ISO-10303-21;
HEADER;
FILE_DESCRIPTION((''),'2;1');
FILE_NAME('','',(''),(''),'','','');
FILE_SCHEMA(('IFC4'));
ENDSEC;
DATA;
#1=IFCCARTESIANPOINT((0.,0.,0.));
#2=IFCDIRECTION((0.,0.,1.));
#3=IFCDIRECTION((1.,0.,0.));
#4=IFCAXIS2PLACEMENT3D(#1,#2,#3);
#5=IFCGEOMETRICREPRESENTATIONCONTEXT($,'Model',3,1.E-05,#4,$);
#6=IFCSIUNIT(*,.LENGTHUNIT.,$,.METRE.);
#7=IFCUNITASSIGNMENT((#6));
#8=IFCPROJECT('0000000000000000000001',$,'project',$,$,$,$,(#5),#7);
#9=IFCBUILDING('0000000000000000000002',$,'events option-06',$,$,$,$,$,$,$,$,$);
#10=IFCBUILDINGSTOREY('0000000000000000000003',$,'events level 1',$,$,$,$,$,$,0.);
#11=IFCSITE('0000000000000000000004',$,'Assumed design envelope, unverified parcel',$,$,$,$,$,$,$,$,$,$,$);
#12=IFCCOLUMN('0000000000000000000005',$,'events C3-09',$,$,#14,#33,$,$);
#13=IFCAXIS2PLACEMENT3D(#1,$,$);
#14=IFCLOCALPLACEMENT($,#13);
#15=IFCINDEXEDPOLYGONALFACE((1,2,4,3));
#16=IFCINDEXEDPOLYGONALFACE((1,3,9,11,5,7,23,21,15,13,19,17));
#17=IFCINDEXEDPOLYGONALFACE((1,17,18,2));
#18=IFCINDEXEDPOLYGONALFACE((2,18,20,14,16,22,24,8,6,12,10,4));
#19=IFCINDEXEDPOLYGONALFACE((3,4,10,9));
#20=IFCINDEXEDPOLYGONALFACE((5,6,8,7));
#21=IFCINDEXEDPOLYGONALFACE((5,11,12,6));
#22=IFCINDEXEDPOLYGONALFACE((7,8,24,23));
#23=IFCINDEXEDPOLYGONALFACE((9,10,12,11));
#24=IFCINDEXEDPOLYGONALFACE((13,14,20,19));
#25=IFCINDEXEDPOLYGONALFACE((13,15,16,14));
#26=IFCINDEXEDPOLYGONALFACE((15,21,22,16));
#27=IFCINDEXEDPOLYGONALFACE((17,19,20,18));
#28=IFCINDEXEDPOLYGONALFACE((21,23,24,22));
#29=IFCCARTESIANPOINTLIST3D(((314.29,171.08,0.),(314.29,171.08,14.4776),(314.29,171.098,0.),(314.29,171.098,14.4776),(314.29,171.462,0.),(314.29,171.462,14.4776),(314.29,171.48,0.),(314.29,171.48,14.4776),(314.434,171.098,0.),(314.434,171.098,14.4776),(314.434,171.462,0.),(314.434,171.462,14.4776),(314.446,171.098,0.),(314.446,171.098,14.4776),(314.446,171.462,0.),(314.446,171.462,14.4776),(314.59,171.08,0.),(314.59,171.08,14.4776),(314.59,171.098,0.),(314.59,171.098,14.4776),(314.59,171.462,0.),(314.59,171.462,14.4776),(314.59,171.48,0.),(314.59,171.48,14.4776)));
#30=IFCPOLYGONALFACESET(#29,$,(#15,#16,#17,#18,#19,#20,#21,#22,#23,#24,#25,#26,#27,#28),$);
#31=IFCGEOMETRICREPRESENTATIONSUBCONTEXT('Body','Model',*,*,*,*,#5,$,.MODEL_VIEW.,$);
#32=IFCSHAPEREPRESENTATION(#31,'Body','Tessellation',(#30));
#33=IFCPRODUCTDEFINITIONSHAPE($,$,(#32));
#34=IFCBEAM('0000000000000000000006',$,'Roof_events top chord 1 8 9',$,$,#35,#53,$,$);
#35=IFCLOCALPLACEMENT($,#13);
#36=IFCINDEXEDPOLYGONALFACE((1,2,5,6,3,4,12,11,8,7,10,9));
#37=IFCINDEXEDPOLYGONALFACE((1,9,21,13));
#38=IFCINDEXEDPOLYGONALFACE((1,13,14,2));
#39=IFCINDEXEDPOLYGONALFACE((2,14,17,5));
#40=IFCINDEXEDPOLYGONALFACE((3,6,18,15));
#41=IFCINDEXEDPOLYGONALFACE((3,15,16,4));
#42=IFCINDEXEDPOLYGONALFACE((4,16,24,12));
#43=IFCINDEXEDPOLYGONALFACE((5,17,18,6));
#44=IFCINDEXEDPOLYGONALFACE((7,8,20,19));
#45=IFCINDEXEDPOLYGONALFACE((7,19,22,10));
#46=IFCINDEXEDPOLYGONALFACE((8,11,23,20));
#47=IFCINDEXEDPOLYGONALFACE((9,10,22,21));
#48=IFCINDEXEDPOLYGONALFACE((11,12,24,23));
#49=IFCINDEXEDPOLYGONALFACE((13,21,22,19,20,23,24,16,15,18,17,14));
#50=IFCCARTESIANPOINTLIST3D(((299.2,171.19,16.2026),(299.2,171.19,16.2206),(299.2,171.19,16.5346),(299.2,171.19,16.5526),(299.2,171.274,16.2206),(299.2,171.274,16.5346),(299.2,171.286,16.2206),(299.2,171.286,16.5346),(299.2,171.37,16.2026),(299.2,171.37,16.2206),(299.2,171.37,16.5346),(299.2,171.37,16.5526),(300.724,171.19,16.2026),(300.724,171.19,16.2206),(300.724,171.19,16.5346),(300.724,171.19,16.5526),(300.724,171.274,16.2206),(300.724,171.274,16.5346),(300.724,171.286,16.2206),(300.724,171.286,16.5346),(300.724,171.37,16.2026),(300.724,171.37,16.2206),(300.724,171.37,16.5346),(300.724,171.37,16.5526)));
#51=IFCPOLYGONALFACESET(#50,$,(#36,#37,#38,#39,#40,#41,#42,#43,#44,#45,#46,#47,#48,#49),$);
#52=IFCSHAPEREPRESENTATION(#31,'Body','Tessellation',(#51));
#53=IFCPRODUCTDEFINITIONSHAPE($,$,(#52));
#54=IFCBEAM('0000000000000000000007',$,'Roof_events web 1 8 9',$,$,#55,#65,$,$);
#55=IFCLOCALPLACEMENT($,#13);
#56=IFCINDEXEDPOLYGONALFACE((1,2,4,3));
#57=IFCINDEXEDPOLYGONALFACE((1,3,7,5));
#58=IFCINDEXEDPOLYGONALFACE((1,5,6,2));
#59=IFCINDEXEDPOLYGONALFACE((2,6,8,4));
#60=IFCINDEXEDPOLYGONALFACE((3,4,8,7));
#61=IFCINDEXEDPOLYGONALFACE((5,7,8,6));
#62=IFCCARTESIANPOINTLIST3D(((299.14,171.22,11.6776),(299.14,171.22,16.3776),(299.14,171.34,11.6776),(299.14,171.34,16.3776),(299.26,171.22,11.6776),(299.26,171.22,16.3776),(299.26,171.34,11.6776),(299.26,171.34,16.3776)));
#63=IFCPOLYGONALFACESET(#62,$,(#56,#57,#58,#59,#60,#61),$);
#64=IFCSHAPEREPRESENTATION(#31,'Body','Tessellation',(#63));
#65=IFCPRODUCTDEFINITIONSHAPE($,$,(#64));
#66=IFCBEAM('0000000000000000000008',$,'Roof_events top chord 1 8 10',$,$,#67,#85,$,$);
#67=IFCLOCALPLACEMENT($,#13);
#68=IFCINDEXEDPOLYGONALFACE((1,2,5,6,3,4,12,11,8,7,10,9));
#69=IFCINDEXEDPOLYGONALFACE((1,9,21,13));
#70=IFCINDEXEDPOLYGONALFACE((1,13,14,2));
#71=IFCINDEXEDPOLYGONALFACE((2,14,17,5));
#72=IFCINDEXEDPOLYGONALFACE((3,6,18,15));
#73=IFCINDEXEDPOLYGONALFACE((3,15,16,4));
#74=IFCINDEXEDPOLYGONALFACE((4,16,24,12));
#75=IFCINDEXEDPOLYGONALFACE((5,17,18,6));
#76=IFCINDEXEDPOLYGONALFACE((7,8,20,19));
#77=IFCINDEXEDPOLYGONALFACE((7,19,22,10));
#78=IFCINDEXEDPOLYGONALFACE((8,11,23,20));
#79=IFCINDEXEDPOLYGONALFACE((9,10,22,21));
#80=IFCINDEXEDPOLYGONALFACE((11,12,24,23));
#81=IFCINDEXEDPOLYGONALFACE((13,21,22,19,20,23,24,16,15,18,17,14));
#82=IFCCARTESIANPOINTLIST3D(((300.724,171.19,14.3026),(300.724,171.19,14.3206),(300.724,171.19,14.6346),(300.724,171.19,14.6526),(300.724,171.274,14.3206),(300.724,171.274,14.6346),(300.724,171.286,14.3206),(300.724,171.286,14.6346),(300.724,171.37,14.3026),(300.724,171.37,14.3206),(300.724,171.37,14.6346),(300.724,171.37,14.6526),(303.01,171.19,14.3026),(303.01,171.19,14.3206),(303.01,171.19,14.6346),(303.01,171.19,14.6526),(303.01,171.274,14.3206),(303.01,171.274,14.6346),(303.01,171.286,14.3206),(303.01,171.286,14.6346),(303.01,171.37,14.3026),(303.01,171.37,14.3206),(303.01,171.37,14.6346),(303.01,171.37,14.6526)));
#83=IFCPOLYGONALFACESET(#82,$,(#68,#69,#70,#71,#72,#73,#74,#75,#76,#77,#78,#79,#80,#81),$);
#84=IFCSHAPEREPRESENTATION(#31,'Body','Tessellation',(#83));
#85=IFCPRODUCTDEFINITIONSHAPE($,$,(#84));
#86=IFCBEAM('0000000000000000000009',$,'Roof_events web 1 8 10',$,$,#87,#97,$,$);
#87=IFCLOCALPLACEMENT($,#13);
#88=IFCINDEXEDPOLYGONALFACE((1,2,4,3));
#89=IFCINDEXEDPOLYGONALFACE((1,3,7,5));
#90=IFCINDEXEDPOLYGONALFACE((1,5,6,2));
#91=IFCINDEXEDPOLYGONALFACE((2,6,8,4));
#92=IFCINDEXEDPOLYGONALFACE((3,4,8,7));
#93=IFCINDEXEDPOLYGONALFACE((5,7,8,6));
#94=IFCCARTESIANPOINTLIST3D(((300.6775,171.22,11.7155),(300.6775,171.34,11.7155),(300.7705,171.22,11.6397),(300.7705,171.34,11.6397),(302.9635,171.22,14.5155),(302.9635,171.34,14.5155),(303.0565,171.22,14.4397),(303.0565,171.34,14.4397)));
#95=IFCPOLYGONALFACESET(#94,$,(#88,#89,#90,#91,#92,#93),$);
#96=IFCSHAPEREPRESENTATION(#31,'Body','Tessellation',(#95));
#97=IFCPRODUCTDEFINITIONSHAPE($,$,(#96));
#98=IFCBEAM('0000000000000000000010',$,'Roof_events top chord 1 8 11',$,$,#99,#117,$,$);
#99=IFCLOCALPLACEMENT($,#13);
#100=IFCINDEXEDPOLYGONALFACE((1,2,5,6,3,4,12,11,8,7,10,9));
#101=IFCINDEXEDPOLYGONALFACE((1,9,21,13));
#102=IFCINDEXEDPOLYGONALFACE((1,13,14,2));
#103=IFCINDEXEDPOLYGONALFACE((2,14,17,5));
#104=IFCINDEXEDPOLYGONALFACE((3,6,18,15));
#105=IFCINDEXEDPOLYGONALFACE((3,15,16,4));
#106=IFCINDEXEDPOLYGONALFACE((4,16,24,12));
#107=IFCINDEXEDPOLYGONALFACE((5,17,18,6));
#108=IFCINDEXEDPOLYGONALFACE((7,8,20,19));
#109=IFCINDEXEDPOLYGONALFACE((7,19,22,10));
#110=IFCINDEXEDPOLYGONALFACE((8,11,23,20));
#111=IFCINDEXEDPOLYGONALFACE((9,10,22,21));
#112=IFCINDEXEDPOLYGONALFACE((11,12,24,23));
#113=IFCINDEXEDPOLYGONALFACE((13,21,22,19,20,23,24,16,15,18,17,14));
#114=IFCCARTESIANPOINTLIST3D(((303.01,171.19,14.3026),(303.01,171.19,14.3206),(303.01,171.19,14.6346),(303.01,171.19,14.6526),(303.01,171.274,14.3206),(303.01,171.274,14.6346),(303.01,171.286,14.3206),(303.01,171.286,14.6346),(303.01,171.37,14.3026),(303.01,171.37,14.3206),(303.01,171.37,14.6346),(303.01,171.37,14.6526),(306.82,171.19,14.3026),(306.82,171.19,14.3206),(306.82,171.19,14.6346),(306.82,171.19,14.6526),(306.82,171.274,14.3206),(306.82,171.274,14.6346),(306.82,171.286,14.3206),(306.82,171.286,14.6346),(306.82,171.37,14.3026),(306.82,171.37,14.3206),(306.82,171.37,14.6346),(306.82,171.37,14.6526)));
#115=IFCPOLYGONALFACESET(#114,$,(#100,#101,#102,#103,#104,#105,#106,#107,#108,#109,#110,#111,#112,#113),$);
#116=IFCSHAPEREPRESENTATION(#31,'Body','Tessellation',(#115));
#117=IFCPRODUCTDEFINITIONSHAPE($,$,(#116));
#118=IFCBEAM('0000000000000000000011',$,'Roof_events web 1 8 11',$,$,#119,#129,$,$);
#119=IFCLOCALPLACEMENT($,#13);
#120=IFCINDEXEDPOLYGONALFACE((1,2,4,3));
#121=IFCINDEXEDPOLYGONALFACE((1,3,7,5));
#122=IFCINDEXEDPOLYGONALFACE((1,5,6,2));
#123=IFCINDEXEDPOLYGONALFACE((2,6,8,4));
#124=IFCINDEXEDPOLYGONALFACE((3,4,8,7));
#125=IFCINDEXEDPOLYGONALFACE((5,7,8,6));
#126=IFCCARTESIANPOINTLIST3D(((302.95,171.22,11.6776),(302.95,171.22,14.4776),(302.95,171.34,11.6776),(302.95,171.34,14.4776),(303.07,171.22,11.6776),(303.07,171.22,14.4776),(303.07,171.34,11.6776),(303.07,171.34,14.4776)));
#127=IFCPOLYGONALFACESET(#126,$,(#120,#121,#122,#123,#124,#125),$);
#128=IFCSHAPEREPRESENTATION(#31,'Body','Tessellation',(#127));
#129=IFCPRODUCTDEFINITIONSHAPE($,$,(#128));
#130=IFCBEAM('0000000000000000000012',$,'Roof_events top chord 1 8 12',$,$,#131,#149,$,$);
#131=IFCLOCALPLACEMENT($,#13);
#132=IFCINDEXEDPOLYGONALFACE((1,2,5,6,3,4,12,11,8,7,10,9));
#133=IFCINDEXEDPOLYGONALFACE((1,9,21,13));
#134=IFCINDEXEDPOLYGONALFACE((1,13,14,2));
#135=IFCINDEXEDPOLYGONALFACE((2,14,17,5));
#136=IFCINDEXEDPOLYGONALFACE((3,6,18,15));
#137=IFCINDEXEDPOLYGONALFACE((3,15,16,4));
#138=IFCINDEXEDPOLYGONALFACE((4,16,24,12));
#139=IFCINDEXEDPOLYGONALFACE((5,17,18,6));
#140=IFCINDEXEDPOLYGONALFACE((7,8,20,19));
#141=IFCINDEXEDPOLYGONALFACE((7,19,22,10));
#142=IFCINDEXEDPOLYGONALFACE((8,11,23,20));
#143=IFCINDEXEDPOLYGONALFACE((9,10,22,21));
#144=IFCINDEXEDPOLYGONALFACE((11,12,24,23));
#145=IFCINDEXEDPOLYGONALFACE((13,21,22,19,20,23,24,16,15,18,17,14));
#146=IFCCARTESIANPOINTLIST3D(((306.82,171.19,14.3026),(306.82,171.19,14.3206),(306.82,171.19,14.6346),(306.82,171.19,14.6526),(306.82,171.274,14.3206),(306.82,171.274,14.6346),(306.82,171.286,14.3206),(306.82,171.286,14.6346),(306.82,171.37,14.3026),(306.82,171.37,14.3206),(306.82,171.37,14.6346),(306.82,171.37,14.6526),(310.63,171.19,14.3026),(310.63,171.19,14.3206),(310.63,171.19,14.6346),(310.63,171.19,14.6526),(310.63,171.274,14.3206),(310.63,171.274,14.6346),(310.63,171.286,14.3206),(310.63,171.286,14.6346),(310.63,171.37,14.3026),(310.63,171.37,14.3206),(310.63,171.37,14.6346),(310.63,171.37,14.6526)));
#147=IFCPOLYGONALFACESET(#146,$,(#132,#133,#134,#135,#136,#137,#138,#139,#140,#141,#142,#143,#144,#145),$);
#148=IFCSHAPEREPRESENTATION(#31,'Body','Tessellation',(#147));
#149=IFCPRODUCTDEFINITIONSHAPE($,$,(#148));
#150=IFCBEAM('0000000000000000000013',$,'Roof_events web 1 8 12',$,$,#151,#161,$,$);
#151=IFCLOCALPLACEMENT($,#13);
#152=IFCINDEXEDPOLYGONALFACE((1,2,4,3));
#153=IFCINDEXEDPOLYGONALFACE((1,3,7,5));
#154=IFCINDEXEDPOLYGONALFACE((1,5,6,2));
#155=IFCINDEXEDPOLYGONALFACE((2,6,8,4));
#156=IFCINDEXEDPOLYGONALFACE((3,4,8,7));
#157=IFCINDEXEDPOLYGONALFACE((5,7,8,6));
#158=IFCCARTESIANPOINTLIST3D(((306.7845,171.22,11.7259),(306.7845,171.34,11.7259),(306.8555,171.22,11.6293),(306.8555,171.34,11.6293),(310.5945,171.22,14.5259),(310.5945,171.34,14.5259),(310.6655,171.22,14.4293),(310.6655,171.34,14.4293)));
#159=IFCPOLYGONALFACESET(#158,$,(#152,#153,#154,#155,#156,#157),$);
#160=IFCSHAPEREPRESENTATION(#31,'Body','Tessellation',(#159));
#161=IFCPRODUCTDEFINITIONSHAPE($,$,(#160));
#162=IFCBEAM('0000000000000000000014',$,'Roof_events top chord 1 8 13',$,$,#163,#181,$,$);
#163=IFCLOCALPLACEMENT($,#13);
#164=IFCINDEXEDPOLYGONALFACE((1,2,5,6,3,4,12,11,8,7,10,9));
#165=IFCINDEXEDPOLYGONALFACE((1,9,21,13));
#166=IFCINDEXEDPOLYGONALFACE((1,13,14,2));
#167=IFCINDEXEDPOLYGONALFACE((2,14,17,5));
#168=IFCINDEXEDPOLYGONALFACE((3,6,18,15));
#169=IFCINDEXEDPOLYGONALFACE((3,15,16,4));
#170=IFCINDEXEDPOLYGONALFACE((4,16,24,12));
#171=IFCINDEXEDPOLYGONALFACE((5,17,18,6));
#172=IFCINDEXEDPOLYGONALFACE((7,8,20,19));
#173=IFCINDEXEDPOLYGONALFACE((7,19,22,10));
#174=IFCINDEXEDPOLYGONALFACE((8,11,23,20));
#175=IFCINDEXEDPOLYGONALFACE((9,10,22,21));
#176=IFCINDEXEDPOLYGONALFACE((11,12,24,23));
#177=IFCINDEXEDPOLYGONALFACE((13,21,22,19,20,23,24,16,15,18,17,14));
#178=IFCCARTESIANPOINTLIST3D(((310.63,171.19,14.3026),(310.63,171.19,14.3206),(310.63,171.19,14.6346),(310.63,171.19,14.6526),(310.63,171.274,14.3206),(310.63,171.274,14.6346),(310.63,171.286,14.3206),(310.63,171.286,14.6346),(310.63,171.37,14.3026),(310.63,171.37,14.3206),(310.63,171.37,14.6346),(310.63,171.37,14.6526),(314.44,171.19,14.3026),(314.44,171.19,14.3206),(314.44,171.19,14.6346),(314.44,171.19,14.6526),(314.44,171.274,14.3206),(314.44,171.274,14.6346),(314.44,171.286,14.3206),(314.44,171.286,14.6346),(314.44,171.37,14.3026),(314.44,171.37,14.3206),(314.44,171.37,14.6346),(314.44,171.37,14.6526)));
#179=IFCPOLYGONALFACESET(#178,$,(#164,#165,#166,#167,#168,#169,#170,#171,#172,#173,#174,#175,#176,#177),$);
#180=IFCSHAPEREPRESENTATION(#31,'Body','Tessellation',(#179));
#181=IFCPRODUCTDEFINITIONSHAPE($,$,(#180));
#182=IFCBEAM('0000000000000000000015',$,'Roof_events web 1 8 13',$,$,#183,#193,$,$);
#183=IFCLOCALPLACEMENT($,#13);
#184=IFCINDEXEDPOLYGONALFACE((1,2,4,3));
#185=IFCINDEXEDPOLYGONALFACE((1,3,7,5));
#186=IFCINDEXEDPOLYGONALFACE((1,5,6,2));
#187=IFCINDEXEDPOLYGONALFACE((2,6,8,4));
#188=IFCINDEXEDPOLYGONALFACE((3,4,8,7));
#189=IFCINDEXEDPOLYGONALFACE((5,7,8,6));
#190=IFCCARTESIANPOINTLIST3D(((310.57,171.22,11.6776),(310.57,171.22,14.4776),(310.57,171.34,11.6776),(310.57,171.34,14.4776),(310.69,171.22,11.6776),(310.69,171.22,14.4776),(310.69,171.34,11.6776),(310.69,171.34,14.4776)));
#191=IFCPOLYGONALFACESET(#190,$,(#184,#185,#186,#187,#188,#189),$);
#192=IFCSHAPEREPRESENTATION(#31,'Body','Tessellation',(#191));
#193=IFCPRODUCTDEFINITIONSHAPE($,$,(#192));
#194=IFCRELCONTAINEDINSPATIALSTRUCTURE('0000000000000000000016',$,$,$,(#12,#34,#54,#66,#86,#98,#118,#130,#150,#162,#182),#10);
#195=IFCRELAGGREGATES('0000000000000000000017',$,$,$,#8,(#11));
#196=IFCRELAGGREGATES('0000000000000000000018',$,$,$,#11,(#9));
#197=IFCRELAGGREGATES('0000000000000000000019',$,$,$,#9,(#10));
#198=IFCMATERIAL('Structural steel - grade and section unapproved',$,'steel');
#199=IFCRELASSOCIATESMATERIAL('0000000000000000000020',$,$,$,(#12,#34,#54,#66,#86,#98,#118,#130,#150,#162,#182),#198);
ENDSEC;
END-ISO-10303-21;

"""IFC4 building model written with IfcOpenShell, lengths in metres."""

from ifc_helpers import new_model, si_unit, frame, origin_with_axes, place, context, subcontext, project, spatial, rectangle, i_section, extrude, material, element, save


model = new_model("IFC4")

# Units and contexts
model_context = context("Model", 3, precision=1e-05, world=origin_with_axes())
body_context = subcontext(model_context, "Body", "Model", "MODEL_VIEW")
ifc_project = project(units=[si_unit("LENGTHUNIT", "METRE")], contexts=[model_context])

# Site, building, storey
site = spatial("IfcSite", under=ifc_project, Name="Assumed design envelope, unverified parcel")
building = spatial("IfcBuilding", under=site, Name="events option-06")
storey = spatial("IfcBuildingStorey", under=building, Name="events level 1", Elevation=0.0)

# Column
ifc_material_1 = material(Name="Structural steel - grade and section unapproved", Category="steel")
column_placement = place(None, frame((314.44, 171.28, 0.0), z_axis=(0.0, 0.0, 1.0), x_axis=(-1.0, 0.0, 0.0)))
element("IfcColumn", 1, at=column_placement, inside=storey, material=ifc_material_1, Name="events C3-09", context=body_context, shape_type="SweptSolid", body=[
    extrude(i_section(OverallWidth=0.3, OverallDepth=0.4, WebThickness=0.012, FlangeThickness=0.018, FilletRadius=0.0), origin_with_axes(), (0.0, 0.0, 1.0), 14.4776),
])

# Beams
beam_1_placement = place(None, frame((299.2, 171.28, 16.3776), z_axis=(1.0, 0.0, 0.0), x_axis=(0.0, 1.0, 0.0)))
element("IfcBeam", 2, at=beam_1_placement, inside=storey, material=ifc_material_1, Name="Roof_events top chord 1 8 9", context=body_context, shape_type="SweptSolid", body=[
    extrude(i_section(OverallWidth=0.18, OverallDepth=0.35, WebThickness=0.012, FlangeThickness=0.018, FilletRadius=0.0), origin_with_axes(), (0.0, 0.0, 1.0), 1.524),
])
beam_2_placement = place(None, frame((299.2, 171.28, 11.6776), z_axis=(0.0, 0.0, 1.0), x_axis=(-1.0, 0.0, 0.0)))
element("IfcBeam", 3, at=beam_2_placement, inside=storey, material=ifc_material_1, Name="Roof_events web 1 8 9", context=body_context, shape_type="SweptSolid", body=[
    extrude(rectangle(XDim=0.12, YDim=0.12), origin_with_axes(), (0.0, 0.0, 1.0), 4.7),
])
beam_3_placement = place(None, frame((300.724, 171.28, 14.4776), z_axis=(1.0, 0.0, 0.0), x_axis=(0.0, 1.0, 0.0)))
element("IfcBeam", 4, at=beam_3_placement, inside=storey, material=ifc_material_1, Name="Roof_events top chord 1 8 10", context=body_context, shape_type="SweptSolid", body=[
    extrude(i_section(OverallWidth=0.18, OverallDepth=0.35, WebThickness=0.012, FlangeThickness=0.018, FilletRadius=0.0), origin_with_axes(), (0.0, 0.0, 1.0), 2.286),
])
beam_4_placement = place(None, frame((300.724, 171.28, 11.6776), z_axis=(0.632426, 0.0, 0.774621), x_axis=(0.0, 1.0, 0.0)))
element("IfcBeam", 5, at=beam_4_placement, inside=storey, material=ifc_material_1, Name="Roof_events web 1 8 10", context=body_context, shape_type="SweptSolid", body=[
    extrude(rectangle(XDim=0.12, YDim=0.12), origin_with_axes(), (0.0, 0.0, 1.0), 3.6147),
])
beam_5_placement = place(None, frame((303.01, 171.28, 14.4776), z_axis=(1.0, 0.0, 0.0), x_axis=(0.0, 1.0, 0.0)))
element("IfcBeam", 6, at=beam_5_placement, inside=storey, material=ifc_material_1, Name="Roof_events top chord 1 8 11", context=body_context, shape_type="SweptSolid", body=[
    extrude(i_section(OverallWidth=0.18, OverallDepth=0.35, WebThickness=0.012, FlangeThickness=0.018, FilletRadius=0.0), origin_with_axes(), (0.0, 0.0, 1.0), 3.81),
])
beam_6_placement = place(None, frame((303.01, 171.28, 11.6776), z_axis=(0.0, 0.0, 1.0), x_axis=(-1.0, 0.0, 0.0)))
element("IfcBeam", 7, at=beam_6_placement, inside=storey, material=ifc_material_1, Name="Roof_events web 1 8 11", context=body_context, shape_type="SweptSolid", body=[
    extrude(rectangle(XDim=0.12, YDim=0.12), origin_with_axes(), (0.0, 0.0, 1.0), 2.8),
])
beam_7_placement = place(None, frame((306.82, 171.28, 14.4776), z_axis=(1.0, 0.0, 0.0), x_axis=(0.0, 1.0, 0.0)))
element("IfcBeam", 8, at=beam_7_placement, inside=storey, material=ifc_material_1, Name="Roof_events top chord 1 8 12", context=body_context, shape_type="SweptSolid", body=[
    extrude(i_section(OverallWidth=0.18, OverallDepth=0.35, WebThickness=0.012, FlangeThickness=0.018, FilletRadius=0.0), origin_with_axes(), (0.0, 0.0, 1.0), 3.81),
])
beam_8_placement = place(None, frame((306.82, 171.28, 11.6776), z_axis=(0.805799, 0.0, 0.592189), x_axis=(0.0, 1.0, 0.0)))
element("IfcBeam", 9, at=beam_8_placement, inside=storey, material=ifc_material_1, Name="Roof_events web 1 8 12", context=body_context, shape_type="SweptSolid", body=[
    extrude(rectangle(XDim=0.12, YDim=0.12), origin_with_axes(), (0.0, 0.0, 1.0), 4.7282),
])
beam_9_placement = place(None, frame((310.63, 171.28, 14.4776), z_axis=(1.0, 0.0, 0.0), x_axis=(0.0, 1.0, 0.0)))
element("IfcBeam", 10, at=beam_9_placement, inside=storey, material=ifc_material_1, Name="Roof_events top chord 1 8 13", context=body_context, shape_type="SweptSolid", body=[
    extrude(i_section(OverallWidth=0.18, OverallDepth=0.35, WebThickness=0.012, FlangeThickness=0.018, FilletRadius=0.0), origin_with_axes(), (0.0, 0.0, 1.0), 3.81),
])
beam_10_placement = place(None, frame((310.63, 171.28, 11.6776), z_axis=(0.0, 0.0, 1.0), x_axis=(-1.0, 0.0, 0.0)))
element("IfcBeam", 11, at=beam_10_placement, inside=storey, material=ifc_material_1, Name="Roof_events web 1 8 13", context=body_context, shape_type="SweptSolid", body=[
    extrude(rectangle(XDim=0.12, YDim=0.12), origin_with_axes(), (0.0, 0.0, 1.0), 2.8),
])

save(model, "model.ifc")
